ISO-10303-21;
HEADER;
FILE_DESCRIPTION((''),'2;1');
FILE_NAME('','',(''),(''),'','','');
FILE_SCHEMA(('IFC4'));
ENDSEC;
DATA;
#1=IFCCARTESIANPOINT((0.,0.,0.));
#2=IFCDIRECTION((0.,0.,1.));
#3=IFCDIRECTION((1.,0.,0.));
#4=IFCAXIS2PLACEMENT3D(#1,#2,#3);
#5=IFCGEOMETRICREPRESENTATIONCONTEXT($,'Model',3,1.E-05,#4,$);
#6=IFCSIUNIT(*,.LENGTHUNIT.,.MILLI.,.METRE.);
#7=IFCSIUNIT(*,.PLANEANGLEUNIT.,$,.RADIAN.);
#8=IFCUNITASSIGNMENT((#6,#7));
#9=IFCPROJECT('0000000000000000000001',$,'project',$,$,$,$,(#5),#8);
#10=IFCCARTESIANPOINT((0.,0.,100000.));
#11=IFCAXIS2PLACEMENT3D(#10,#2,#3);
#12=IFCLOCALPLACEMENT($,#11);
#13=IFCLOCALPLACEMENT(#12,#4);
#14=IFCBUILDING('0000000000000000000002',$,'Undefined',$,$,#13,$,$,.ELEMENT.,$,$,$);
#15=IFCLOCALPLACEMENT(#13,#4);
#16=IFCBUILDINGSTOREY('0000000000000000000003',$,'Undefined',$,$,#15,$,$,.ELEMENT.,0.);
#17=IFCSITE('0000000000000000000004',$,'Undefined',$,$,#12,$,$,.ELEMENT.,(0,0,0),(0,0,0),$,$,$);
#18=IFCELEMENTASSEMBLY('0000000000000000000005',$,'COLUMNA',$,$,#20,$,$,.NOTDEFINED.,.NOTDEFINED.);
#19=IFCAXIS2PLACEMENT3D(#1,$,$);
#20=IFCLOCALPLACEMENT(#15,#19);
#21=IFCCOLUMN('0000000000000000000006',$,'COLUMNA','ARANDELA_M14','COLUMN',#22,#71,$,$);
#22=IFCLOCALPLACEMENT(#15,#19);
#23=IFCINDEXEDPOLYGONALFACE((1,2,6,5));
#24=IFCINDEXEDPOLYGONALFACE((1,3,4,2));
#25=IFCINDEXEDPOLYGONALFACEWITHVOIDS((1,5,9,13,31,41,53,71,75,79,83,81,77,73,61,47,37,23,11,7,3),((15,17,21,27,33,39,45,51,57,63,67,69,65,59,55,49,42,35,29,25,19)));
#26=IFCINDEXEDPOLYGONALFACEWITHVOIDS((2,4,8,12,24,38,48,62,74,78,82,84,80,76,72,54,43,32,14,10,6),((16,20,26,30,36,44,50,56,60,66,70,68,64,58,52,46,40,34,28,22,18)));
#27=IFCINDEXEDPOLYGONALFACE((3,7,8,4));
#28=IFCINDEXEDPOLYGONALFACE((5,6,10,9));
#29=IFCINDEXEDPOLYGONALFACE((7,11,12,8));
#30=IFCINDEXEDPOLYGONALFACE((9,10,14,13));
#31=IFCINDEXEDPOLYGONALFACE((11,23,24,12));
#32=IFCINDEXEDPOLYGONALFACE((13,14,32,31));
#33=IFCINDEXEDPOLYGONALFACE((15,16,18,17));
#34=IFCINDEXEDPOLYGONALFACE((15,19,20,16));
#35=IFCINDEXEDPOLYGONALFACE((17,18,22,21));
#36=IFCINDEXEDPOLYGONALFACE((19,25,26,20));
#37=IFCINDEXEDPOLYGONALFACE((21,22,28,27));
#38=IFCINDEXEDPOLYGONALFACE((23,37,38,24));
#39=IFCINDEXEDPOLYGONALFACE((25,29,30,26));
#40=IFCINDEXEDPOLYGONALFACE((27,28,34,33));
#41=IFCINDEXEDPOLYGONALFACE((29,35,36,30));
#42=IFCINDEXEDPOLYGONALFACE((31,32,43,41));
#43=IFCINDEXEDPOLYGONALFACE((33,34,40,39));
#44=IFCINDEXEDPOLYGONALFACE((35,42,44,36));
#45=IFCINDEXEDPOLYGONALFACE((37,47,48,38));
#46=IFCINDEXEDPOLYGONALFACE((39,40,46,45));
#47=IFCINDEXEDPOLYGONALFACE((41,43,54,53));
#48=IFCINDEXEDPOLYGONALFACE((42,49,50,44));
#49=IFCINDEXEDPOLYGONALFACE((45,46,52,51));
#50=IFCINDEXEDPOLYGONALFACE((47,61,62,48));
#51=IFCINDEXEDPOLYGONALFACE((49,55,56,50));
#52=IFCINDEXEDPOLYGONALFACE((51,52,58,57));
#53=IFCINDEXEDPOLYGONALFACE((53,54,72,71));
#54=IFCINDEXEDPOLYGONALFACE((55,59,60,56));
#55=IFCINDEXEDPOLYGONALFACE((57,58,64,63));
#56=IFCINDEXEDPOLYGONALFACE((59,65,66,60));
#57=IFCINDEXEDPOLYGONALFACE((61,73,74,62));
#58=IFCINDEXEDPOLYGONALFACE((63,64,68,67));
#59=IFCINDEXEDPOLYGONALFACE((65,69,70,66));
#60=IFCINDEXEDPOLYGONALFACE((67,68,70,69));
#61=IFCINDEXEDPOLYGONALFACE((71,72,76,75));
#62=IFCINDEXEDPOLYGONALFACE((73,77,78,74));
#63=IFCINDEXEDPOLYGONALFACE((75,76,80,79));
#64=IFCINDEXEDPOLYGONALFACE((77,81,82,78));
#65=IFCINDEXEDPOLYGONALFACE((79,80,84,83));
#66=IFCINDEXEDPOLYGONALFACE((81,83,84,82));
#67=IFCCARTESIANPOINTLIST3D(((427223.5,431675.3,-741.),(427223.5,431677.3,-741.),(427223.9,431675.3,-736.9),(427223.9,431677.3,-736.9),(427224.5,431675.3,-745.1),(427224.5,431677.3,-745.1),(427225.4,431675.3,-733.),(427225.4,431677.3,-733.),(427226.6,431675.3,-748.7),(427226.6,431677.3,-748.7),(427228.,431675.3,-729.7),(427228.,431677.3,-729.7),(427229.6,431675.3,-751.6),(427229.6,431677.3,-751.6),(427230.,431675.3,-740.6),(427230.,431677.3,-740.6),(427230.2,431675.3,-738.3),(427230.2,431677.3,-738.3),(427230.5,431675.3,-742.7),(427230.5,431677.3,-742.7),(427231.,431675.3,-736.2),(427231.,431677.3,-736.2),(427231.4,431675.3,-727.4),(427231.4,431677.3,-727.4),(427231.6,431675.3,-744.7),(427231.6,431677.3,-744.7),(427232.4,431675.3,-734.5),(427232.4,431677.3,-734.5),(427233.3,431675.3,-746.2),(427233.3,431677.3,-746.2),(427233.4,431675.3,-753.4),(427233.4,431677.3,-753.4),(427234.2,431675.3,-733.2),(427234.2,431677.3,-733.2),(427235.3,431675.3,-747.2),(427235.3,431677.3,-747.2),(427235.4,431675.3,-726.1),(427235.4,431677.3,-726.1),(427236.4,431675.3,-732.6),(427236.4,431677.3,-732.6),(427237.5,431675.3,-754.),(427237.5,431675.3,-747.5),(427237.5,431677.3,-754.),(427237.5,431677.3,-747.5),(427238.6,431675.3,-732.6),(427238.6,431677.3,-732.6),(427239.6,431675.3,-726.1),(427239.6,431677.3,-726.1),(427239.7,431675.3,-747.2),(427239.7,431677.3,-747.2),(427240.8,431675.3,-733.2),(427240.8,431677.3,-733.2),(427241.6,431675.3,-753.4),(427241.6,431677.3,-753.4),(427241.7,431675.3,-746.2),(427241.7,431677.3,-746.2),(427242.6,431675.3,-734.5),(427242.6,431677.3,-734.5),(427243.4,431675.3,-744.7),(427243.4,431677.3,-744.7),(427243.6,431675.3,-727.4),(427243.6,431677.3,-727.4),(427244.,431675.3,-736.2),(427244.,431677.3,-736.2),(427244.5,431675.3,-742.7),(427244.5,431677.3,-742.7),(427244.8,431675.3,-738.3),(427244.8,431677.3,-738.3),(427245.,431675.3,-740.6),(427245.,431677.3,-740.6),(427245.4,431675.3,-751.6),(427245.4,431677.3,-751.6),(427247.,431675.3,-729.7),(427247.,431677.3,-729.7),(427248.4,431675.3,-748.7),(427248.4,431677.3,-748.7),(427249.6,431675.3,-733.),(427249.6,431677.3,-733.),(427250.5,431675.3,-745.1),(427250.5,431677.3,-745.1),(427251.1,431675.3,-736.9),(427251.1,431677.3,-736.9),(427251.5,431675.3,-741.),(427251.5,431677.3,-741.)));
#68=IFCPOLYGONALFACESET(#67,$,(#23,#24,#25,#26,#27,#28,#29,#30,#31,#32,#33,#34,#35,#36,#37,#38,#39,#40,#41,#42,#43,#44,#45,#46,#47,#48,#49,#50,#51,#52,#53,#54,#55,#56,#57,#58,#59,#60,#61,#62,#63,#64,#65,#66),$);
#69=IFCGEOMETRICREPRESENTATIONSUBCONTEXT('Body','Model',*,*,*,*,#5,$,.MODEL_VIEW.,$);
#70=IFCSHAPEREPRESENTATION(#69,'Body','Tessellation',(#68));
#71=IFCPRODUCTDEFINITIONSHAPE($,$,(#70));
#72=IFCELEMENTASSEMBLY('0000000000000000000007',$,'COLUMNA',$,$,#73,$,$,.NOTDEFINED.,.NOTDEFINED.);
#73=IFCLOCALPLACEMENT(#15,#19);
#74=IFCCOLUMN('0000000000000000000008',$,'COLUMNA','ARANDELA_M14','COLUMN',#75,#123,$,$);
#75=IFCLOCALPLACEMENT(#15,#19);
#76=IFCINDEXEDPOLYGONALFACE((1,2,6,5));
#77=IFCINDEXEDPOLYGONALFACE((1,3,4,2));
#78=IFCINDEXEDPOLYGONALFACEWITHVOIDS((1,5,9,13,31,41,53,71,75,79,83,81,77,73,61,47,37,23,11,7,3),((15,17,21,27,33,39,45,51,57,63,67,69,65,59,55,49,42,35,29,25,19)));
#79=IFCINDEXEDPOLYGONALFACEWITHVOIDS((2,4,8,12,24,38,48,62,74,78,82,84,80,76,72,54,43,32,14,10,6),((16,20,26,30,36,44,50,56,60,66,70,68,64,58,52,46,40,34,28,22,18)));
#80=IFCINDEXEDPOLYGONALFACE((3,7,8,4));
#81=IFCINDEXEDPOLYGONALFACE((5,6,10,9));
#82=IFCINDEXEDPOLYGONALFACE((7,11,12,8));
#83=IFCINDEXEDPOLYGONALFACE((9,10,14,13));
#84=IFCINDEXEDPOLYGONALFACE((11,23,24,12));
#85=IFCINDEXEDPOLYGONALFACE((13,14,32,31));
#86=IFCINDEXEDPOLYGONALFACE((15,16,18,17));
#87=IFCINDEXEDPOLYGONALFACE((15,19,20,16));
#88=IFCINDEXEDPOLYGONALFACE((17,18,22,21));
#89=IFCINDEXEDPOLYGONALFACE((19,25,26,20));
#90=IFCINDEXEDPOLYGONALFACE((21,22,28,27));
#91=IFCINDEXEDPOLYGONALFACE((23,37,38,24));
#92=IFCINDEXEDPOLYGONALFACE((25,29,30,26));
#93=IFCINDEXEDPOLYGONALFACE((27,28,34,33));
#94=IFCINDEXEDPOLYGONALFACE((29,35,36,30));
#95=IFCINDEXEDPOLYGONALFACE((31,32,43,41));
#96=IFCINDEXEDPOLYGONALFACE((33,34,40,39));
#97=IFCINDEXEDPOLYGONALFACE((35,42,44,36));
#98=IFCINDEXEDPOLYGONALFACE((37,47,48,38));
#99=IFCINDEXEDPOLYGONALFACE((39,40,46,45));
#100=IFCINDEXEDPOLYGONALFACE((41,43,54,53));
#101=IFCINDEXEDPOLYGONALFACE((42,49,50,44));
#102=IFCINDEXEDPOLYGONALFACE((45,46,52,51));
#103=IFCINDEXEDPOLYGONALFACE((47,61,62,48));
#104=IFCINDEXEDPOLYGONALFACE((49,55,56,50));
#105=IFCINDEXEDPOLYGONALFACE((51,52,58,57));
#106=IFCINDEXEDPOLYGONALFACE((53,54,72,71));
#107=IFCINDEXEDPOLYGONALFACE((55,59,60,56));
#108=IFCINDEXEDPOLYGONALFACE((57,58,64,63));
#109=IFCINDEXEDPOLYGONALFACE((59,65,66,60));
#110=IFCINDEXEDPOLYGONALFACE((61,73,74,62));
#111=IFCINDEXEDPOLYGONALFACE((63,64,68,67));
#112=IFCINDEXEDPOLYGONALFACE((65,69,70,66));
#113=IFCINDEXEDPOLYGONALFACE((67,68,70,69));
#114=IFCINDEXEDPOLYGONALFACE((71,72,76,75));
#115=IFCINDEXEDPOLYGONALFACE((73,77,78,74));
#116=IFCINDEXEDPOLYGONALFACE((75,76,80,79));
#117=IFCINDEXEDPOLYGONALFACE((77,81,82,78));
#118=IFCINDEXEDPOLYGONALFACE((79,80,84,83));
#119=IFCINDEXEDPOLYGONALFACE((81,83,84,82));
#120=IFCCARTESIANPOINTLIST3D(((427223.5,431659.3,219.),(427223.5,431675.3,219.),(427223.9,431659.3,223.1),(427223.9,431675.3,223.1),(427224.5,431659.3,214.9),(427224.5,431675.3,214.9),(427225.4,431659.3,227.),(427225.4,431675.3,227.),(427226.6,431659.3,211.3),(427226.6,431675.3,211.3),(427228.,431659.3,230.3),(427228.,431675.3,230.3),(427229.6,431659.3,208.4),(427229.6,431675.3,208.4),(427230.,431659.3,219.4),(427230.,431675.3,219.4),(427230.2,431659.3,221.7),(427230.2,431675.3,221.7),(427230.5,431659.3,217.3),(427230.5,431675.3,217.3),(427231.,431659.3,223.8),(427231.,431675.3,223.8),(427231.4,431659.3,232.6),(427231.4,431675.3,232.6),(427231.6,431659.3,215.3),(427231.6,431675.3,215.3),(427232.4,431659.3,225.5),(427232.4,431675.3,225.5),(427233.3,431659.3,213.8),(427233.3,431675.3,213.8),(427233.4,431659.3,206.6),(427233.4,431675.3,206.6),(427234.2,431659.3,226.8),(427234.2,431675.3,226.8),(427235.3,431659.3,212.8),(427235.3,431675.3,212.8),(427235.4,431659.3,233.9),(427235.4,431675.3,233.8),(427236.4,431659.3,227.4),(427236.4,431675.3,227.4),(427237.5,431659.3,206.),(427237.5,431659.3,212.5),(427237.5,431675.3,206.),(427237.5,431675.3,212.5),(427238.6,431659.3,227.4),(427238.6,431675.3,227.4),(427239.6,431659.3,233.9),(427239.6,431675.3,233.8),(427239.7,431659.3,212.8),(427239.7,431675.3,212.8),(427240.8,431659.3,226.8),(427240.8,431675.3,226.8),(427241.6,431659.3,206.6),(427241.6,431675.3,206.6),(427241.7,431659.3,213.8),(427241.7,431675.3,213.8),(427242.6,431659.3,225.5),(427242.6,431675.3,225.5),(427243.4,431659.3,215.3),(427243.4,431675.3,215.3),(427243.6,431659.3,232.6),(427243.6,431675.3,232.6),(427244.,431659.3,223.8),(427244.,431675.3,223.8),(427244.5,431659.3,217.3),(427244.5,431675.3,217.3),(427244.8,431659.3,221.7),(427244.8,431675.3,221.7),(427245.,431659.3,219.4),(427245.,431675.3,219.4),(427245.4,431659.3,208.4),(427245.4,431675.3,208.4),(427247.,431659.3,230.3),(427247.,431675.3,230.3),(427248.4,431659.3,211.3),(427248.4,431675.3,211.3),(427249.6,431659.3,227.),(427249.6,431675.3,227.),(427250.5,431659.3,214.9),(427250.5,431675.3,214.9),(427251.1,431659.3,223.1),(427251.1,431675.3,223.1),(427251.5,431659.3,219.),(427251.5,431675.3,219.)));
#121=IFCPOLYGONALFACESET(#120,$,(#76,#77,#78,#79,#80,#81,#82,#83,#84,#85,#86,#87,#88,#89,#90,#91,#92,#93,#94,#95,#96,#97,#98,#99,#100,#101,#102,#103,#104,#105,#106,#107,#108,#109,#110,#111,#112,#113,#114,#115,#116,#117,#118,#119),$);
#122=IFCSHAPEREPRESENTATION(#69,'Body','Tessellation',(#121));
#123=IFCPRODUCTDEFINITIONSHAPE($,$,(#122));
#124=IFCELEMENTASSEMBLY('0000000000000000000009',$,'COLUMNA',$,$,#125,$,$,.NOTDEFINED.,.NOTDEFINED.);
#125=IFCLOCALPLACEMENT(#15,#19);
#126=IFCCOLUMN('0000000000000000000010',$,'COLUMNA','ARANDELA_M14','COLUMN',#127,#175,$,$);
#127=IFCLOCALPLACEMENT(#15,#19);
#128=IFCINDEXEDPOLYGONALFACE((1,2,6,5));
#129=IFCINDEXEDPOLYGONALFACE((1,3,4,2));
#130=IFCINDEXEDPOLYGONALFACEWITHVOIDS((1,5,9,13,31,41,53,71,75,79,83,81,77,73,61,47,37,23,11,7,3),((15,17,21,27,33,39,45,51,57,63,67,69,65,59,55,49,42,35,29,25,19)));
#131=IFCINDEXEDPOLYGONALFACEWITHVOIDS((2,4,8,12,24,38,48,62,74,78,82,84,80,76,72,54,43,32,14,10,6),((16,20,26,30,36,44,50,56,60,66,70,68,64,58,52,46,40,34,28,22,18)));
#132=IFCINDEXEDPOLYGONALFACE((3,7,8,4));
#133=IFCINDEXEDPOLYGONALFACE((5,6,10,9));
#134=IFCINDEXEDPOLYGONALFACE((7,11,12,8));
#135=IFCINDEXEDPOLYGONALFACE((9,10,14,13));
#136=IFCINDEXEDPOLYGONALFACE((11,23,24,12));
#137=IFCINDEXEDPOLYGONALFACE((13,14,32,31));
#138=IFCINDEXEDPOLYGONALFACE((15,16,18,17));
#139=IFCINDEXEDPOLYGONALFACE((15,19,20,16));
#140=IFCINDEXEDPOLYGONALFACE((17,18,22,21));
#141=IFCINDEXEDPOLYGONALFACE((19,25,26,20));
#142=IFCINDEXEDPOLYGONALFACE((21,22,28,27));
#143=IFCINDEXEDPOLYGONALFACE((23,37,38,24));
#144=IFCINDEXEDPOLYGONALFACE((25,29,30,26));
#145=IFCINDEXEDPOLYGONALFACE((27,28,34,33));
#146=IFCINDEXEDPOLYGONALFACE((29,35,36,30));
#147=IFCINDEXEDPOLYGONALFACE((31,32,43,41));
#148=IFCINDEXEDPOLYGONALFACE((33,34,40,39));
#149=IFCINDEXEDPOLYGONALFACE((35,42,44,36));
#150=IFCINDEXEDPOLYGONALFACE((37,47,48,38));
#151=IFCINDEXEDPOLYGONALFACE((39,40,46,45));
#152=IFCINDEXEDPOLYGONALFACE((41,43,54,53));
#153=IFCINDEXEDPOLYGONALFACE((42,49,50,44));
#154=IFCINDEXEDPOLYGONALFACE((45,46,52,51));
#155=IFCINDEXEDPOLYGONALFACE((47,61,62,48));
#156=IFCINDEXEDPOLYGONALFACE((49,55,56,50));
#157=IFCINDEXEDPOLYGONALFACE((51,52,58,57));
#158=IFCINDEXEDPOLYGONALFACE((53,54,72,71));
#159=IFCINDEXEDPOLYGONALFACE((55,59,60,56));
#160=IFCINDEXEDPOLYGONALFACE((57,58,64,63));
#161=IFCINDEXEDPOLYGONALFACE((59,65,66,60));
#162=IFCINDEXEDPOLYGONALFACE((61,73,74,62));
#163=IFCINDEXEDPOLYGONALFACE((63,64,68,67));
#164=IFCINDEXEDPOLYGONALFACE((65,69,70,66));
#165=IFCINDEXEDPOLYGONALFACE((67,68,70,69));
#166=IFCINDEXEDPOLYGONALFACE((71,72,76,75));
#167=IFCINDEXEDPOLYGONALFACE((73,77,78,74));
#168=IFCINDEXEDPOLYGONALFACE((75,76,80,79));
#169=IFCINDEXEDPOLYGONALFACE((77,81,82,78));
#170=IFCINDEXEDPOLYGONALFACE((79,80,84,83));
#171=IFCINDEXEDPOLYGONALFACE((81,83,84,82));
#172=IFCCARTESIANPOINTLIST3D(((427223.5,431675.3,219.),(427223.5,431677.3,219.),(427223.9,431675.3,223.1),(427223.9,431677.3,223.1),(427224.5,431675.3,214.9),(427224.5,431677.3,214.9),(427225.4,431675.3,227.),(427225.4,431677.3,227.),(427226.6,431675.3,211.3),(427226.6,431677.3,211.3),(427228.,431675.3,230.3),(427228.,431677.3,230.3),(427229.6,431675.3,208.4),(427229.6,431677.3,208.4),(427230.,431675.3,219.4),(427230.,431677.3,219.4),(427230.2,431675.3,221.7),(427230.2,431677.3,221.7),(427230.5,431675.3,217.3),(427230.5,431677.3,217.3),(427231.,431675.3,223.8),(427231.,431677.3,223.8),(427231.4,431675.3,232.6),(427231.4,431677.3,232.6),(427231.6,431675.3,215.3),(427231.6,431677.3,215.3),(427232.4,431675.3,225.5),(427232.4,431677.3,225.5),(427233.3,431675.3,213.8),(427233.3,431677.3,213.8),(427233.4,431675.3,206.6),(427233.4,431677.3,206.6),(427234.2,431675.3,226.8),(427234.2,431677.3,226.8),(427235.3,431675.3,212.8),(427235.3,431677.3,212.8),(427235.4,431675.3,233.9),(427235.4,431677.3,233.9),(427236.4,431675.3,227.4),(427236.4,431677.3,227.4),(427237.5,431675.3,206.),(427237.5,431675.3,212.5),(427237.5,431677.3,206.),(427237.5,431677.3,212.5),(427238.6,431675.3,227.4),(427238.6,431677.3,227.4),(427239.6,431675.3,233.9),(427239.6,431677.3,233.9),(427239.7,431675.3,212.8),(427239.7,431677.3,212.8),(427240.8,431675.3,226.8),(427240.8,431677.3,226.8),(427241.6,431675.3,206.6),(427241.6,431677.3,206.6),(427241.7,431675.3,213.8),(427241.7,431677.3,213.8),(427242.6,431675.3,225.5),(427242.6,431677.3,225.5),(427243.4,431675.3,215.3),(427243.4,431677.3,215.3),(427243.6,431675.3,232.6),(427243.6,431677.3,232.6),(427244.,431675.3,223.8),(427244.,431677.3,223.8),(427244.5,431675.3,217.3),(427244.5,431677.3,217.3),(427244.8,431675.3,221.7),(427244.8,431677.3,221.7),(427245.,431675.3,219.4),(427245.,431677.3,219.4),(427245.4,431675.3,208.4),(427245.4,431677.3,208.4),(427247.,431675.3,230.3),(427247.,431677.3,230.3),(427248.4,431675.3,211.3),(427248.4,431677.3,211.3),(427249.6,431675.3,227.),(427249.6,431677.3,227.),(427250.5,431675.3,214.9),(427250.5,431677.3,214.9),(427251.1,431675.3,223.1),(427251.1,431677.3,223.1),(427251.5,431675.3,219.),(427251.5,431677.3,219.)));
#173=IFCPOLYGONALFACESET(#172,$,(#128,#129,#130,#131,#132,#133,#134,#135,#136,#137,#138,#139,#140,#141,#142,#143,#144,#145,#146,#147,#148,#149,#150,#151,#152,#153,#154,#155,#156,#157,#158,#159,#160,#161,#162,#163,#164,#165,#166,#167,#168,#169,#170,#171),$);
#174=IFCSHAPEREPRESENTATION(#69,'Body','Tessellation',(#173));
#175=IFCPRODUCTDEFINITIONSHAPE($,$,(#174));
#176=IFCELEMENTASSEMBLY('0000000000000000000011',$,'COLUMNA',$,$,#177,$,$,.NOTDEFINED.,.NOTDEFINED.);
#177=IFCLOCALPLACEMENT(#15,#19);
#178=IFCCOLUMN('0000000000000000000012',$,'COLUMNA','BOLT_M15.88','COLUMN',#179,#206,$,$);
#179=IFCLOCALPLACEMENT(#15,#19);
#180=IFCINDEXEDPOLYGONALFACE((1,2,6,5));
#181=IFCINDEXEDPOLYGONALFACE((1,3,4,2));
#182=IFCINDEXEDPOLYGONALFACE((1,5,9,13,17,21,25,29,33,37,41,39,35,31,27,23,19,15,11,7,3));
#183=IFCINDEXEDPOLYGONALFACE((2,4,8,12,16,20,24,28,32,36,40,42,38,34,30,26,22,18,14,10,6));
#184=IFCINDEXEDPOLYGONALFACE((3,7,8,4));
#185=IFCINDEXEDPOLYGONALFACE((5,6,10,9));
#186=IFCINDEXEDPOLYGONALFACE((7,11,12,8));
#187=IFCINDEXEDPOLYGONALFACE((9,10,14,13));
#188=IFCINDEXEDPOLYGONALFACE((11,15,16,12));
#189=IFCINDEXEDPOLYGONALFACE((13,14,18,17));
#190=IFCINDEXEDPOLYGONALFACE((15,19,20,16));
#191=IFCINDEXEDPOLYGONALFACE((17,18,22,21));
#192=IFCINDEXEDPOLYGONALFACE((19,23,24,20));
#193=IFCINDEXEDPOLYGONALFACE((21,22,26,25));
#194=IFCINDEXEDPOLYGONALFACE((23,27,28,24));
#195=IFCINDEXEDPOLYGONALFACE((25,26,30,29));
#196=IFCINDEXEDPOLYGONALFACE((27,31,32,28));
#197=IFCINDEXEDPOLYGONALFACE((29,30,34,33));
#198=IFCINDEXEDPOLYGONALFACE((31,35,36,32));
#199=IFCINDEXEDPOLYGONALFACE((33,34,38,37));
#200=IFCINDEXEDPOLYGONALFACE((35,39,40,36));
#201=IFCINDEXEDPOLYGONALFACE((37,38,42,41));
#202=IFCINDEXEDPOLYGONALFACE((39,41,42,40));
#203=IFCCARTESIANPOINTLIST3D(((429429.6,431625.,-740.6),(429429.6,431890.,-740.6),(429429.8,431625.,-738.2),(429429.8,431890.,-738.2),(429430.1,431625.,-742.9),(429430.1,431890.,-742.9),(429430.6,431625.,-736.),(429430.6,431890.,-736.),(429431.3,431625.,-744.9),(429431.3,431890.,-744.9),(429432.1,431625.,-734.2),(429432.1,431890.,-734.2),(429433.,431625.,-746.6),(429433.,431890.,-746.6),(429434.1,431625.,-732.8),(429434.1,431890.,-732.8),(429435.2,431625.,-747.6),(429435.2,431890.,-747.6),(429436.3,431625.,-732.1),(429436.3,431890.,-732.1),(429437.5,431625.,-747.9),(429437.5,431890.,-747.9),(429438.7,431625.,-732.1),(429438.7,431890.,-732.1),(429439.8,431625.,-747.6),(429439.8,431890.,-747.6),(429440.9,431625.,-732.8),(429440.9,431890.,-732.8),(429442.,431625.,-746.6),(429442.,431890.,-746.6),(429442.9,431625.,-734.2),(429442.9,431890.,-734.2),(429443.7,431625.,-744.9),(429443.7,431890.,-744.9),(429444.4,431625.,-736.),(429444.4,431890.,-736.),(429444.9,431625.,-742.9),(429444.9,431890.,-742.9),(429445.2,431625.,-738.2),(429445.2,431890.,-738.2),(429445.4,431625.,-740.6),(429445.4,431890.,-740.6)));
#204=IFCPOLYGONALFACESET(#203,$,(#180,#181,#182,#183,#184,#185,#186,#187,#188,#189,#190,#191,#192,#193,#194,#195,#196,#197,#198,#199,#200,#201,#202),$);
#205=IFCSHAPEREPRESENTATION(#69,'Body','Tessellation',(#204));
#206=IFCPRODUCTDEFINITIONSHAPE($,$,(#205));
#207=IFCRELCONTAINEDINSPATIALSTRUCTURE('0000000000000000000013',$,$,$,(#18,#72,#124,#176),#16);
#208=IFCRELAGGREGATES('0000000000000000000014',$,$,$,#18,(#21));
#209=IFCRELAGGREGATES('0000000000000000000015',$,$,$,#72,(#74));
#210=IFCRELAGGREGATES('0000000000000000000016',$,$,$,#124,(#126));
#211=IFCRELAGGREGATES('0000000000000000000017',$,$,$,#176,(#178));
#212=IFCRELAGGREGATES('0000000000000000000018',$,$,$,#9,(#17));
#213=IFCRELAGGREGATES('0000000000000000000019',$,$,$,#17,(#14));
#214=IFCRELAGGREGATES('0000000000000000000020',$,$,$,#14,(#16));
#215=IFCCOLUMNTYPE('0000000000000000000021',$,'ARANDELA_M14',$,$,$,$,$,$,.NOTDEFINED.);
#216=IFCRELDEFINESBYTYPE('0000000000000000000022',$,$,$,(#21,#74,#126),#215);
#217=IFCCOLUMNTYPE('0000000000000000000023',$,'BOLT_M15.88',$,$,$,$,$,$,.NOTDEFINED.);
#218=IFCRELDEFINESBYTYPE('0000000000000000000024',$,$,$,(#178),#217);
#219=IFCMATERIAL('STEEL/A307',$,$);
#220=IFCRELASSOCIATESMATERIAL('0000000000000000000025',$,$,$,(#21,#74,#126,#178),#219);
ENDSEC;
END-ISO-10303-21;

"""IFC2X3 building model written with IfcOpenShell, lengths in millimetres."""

from ifc_helpers import new_model, si_unit, frame, origin_with_axes, origin_2d_with_axis, place, context, subcontext, project, spatial, circle, hollow_circle, extrude, material, type_object, element, aggregate, save


model = new_model("IFC2X3")

# Units and contexts
model_context = context("Model", 3, precision=1e-05, world=origin_with_axes())
body_context = subcontext(model_context, "Body", "Model", "MODEL_VIEW")
ifc_project = project(units=[si_unit("LENGTHUNIT", "METRE", prefix="MILLI"), si_unit("PLANEANGLEUNIT", "RADIAN")], contexts=[model_context])

# Site, building, storey
site_placement = place(None, frame((0.0, 0.0, 100000.0), z_axis=(0.0, 0.0, 1.0), x_axis=(1.0, 0.0, 0.0)))
site = spatial("IfcSite", under=ifc_project, at=site_placement, Name="Undefined", CompositionType="ELEMENT", RefLatitude=(0, 0, 0), RefLongitude=(0, 0, 0))
building_placement = place(site_placement, origin_with_axes())
building = spatial("IfcBuilding", under=site, at=building_placement, Name="Undefined", CompositionType="ELEMENT")
storey_placement = place(building_placement, origin_with_axes())
storey = spatial("IfcBuildingStorey", under=building, at=storey_placement, Name="Undefined", CompositionType="ELEMENT", Elevation=0.0)

# Element assemblies, columns
ifc_material_1 = material(Name="STEEL/A307")
column_type_1 = type_object("IfcColumnType", Name="ARANDELA_M14", PredefinedType="NOTDEFINED")
assembly_1_placement = place(storey_placement, origin_with_axes())
assembly_1 = element("IfcElementAssembly", 1, at=assembly_1_placement, inside=storey, Name="COLUMNA", AssemblyPlace="NOTDEFINED", PredefinedType="NOTDEFINED")
column_1_placement = place(assembly_1_placement, frame((427237.5, 431677.3, -740.0), z_axis=(0.0, -1.0, 0.000285), x_axis=(-1.0, 0.0, 0.0)))
column_1 = element("IfcColumn", 2, at=column_1_placement, type_object=column_type_1, material=ifc_material_1, Name="COLUMNA", Description="ARANDELA_M14", ObjectType="COLUMN", context=body_context, shape_type="SweptSolid", body=[
    extrude(hollow_circle(Radius=14.0, WallThickness=6.5, at=origin_2d_with_axis()), frame((0.0, 0.0, 2.0), z_axis=(0.0, 0.0, -1.0), x_axis=(0.0, 1.0, 0.0)), (0.0, 0.0, 1.0), 2.0),
])
aggregate(assembly_1, [column_1])
assembly_2_placement = place(storey_placement, origin_with_axes())
assembly_2 = element("IfcElementAssembly", 3, at=assembly_2_placement, inside=storey, Name="COLUMNA", AssemblyPlace="NOTDEFINED", PredefinedType="NOTDEFINED")
column_2_placement = place(assembly_2_placement, frame((427237.5, 431675.3, 220.0), z_axis=(0.0, -1.0, 0.000285), x_axis=(-1.0, 0.0, 0.0)))
column_2 = element("IfcColumn", 4, at=column_2_placement, type_object=column_type_1, material=ifc_material_1, Name="COLUMNA", Description="ARANDELA_M14", ObjectType="COLUMN", context=body_context, shape_type="SweptSolid", body=[
    extrude(hollow_circle(Radius=14.0, WallThickness=6.5, at=origin_2d_with_axis()), frame((0.0, 0.0, 16.0), z_axis=(0.0, 0.0, -1.0), x_axis=(0.0, 1.0, 0.0)), (0.0, 0.0, 1.0), 16.0),
])
aggregate(assembly_2, [column_2])
assembly_3_placement = place(storey_placement, origin_with_axes())
assembly_3 = element("IfcElementAssembly", 5, at=assembly_3_placement, inside=storey, Name="COLUMNA", AssemblyPlace="NOTDEFINED", PredefinedType="NOTDEFINED")
column_3_placement = place(assembly_3_placement, frame((427237.5, 431677.3, 220.0), z_axis=(0.0, -1.0, 0.000285), x_axis=(-1.0, 0.0, 0.0)))
column_3 = element("IfcColumn", 6, at=column_3_placement, type_object=column_type_1, material=ifc_material_1, Name="COLUMNA", Description="ARANDELA_M14", ObjectType="COLUMN", context=body_context, shape_type="SweptSolid", body=[
    extrude(hollow_circle(Radius=14.0, WallThickness=6.5, at=origin_2d_with_axis()), frame((0.0, 0.0, 2.0), z_axis=(0.0, 0.0, -1.0), x_axis=(0.0, 1.0, 0.0)), (0.0, 0.0, 1.0), 2.0),
])
aggregate(assembly_3, [column_3])
assembly_4_placement = place(storey_placement, origin_with_axes())
assembly_4 = element("IfcElementAssembly", 7, at=assembly_4_placement, inside=storey, Name="COLUMNA", AssemblyPlace="NOTDEFINED", PredefinedType="NOTDEFINED")
column_type_2 = type_object("IfcColumnType", Name="BOLT_M15.88", PredefinedType="NOTDEFINED")
column_4_placement = place(assembly_4_placement, frame((429437.5, 431890.0, -740.0), z_axis=(0.0, -1.0, -0.000003), x_axis=(-1.0, 0.0, 0.0)))
column_4 = element("IfcColumn", 8, at=column_4_placement, type_object=column_type_2, material=ifc_material_1, Name="COLUMNA", Description="BOLT_M15.88", ObjectType="COLUMN", context=body_context, shape_type="SweptSolid", body=[
    extrude(circle(Radius=7.9, at=origin_2d_with_axis()), frame((0.0, 0.0, 265.0), z_axis=(0.0, 0.0, -1.0), x_axis=(0.0, 1.0, 0.0)), (0.0, 0.0, 1.0), 265.0),
])
aggregate(assembly_4, [column_4])

save(model, "model.ifc")
